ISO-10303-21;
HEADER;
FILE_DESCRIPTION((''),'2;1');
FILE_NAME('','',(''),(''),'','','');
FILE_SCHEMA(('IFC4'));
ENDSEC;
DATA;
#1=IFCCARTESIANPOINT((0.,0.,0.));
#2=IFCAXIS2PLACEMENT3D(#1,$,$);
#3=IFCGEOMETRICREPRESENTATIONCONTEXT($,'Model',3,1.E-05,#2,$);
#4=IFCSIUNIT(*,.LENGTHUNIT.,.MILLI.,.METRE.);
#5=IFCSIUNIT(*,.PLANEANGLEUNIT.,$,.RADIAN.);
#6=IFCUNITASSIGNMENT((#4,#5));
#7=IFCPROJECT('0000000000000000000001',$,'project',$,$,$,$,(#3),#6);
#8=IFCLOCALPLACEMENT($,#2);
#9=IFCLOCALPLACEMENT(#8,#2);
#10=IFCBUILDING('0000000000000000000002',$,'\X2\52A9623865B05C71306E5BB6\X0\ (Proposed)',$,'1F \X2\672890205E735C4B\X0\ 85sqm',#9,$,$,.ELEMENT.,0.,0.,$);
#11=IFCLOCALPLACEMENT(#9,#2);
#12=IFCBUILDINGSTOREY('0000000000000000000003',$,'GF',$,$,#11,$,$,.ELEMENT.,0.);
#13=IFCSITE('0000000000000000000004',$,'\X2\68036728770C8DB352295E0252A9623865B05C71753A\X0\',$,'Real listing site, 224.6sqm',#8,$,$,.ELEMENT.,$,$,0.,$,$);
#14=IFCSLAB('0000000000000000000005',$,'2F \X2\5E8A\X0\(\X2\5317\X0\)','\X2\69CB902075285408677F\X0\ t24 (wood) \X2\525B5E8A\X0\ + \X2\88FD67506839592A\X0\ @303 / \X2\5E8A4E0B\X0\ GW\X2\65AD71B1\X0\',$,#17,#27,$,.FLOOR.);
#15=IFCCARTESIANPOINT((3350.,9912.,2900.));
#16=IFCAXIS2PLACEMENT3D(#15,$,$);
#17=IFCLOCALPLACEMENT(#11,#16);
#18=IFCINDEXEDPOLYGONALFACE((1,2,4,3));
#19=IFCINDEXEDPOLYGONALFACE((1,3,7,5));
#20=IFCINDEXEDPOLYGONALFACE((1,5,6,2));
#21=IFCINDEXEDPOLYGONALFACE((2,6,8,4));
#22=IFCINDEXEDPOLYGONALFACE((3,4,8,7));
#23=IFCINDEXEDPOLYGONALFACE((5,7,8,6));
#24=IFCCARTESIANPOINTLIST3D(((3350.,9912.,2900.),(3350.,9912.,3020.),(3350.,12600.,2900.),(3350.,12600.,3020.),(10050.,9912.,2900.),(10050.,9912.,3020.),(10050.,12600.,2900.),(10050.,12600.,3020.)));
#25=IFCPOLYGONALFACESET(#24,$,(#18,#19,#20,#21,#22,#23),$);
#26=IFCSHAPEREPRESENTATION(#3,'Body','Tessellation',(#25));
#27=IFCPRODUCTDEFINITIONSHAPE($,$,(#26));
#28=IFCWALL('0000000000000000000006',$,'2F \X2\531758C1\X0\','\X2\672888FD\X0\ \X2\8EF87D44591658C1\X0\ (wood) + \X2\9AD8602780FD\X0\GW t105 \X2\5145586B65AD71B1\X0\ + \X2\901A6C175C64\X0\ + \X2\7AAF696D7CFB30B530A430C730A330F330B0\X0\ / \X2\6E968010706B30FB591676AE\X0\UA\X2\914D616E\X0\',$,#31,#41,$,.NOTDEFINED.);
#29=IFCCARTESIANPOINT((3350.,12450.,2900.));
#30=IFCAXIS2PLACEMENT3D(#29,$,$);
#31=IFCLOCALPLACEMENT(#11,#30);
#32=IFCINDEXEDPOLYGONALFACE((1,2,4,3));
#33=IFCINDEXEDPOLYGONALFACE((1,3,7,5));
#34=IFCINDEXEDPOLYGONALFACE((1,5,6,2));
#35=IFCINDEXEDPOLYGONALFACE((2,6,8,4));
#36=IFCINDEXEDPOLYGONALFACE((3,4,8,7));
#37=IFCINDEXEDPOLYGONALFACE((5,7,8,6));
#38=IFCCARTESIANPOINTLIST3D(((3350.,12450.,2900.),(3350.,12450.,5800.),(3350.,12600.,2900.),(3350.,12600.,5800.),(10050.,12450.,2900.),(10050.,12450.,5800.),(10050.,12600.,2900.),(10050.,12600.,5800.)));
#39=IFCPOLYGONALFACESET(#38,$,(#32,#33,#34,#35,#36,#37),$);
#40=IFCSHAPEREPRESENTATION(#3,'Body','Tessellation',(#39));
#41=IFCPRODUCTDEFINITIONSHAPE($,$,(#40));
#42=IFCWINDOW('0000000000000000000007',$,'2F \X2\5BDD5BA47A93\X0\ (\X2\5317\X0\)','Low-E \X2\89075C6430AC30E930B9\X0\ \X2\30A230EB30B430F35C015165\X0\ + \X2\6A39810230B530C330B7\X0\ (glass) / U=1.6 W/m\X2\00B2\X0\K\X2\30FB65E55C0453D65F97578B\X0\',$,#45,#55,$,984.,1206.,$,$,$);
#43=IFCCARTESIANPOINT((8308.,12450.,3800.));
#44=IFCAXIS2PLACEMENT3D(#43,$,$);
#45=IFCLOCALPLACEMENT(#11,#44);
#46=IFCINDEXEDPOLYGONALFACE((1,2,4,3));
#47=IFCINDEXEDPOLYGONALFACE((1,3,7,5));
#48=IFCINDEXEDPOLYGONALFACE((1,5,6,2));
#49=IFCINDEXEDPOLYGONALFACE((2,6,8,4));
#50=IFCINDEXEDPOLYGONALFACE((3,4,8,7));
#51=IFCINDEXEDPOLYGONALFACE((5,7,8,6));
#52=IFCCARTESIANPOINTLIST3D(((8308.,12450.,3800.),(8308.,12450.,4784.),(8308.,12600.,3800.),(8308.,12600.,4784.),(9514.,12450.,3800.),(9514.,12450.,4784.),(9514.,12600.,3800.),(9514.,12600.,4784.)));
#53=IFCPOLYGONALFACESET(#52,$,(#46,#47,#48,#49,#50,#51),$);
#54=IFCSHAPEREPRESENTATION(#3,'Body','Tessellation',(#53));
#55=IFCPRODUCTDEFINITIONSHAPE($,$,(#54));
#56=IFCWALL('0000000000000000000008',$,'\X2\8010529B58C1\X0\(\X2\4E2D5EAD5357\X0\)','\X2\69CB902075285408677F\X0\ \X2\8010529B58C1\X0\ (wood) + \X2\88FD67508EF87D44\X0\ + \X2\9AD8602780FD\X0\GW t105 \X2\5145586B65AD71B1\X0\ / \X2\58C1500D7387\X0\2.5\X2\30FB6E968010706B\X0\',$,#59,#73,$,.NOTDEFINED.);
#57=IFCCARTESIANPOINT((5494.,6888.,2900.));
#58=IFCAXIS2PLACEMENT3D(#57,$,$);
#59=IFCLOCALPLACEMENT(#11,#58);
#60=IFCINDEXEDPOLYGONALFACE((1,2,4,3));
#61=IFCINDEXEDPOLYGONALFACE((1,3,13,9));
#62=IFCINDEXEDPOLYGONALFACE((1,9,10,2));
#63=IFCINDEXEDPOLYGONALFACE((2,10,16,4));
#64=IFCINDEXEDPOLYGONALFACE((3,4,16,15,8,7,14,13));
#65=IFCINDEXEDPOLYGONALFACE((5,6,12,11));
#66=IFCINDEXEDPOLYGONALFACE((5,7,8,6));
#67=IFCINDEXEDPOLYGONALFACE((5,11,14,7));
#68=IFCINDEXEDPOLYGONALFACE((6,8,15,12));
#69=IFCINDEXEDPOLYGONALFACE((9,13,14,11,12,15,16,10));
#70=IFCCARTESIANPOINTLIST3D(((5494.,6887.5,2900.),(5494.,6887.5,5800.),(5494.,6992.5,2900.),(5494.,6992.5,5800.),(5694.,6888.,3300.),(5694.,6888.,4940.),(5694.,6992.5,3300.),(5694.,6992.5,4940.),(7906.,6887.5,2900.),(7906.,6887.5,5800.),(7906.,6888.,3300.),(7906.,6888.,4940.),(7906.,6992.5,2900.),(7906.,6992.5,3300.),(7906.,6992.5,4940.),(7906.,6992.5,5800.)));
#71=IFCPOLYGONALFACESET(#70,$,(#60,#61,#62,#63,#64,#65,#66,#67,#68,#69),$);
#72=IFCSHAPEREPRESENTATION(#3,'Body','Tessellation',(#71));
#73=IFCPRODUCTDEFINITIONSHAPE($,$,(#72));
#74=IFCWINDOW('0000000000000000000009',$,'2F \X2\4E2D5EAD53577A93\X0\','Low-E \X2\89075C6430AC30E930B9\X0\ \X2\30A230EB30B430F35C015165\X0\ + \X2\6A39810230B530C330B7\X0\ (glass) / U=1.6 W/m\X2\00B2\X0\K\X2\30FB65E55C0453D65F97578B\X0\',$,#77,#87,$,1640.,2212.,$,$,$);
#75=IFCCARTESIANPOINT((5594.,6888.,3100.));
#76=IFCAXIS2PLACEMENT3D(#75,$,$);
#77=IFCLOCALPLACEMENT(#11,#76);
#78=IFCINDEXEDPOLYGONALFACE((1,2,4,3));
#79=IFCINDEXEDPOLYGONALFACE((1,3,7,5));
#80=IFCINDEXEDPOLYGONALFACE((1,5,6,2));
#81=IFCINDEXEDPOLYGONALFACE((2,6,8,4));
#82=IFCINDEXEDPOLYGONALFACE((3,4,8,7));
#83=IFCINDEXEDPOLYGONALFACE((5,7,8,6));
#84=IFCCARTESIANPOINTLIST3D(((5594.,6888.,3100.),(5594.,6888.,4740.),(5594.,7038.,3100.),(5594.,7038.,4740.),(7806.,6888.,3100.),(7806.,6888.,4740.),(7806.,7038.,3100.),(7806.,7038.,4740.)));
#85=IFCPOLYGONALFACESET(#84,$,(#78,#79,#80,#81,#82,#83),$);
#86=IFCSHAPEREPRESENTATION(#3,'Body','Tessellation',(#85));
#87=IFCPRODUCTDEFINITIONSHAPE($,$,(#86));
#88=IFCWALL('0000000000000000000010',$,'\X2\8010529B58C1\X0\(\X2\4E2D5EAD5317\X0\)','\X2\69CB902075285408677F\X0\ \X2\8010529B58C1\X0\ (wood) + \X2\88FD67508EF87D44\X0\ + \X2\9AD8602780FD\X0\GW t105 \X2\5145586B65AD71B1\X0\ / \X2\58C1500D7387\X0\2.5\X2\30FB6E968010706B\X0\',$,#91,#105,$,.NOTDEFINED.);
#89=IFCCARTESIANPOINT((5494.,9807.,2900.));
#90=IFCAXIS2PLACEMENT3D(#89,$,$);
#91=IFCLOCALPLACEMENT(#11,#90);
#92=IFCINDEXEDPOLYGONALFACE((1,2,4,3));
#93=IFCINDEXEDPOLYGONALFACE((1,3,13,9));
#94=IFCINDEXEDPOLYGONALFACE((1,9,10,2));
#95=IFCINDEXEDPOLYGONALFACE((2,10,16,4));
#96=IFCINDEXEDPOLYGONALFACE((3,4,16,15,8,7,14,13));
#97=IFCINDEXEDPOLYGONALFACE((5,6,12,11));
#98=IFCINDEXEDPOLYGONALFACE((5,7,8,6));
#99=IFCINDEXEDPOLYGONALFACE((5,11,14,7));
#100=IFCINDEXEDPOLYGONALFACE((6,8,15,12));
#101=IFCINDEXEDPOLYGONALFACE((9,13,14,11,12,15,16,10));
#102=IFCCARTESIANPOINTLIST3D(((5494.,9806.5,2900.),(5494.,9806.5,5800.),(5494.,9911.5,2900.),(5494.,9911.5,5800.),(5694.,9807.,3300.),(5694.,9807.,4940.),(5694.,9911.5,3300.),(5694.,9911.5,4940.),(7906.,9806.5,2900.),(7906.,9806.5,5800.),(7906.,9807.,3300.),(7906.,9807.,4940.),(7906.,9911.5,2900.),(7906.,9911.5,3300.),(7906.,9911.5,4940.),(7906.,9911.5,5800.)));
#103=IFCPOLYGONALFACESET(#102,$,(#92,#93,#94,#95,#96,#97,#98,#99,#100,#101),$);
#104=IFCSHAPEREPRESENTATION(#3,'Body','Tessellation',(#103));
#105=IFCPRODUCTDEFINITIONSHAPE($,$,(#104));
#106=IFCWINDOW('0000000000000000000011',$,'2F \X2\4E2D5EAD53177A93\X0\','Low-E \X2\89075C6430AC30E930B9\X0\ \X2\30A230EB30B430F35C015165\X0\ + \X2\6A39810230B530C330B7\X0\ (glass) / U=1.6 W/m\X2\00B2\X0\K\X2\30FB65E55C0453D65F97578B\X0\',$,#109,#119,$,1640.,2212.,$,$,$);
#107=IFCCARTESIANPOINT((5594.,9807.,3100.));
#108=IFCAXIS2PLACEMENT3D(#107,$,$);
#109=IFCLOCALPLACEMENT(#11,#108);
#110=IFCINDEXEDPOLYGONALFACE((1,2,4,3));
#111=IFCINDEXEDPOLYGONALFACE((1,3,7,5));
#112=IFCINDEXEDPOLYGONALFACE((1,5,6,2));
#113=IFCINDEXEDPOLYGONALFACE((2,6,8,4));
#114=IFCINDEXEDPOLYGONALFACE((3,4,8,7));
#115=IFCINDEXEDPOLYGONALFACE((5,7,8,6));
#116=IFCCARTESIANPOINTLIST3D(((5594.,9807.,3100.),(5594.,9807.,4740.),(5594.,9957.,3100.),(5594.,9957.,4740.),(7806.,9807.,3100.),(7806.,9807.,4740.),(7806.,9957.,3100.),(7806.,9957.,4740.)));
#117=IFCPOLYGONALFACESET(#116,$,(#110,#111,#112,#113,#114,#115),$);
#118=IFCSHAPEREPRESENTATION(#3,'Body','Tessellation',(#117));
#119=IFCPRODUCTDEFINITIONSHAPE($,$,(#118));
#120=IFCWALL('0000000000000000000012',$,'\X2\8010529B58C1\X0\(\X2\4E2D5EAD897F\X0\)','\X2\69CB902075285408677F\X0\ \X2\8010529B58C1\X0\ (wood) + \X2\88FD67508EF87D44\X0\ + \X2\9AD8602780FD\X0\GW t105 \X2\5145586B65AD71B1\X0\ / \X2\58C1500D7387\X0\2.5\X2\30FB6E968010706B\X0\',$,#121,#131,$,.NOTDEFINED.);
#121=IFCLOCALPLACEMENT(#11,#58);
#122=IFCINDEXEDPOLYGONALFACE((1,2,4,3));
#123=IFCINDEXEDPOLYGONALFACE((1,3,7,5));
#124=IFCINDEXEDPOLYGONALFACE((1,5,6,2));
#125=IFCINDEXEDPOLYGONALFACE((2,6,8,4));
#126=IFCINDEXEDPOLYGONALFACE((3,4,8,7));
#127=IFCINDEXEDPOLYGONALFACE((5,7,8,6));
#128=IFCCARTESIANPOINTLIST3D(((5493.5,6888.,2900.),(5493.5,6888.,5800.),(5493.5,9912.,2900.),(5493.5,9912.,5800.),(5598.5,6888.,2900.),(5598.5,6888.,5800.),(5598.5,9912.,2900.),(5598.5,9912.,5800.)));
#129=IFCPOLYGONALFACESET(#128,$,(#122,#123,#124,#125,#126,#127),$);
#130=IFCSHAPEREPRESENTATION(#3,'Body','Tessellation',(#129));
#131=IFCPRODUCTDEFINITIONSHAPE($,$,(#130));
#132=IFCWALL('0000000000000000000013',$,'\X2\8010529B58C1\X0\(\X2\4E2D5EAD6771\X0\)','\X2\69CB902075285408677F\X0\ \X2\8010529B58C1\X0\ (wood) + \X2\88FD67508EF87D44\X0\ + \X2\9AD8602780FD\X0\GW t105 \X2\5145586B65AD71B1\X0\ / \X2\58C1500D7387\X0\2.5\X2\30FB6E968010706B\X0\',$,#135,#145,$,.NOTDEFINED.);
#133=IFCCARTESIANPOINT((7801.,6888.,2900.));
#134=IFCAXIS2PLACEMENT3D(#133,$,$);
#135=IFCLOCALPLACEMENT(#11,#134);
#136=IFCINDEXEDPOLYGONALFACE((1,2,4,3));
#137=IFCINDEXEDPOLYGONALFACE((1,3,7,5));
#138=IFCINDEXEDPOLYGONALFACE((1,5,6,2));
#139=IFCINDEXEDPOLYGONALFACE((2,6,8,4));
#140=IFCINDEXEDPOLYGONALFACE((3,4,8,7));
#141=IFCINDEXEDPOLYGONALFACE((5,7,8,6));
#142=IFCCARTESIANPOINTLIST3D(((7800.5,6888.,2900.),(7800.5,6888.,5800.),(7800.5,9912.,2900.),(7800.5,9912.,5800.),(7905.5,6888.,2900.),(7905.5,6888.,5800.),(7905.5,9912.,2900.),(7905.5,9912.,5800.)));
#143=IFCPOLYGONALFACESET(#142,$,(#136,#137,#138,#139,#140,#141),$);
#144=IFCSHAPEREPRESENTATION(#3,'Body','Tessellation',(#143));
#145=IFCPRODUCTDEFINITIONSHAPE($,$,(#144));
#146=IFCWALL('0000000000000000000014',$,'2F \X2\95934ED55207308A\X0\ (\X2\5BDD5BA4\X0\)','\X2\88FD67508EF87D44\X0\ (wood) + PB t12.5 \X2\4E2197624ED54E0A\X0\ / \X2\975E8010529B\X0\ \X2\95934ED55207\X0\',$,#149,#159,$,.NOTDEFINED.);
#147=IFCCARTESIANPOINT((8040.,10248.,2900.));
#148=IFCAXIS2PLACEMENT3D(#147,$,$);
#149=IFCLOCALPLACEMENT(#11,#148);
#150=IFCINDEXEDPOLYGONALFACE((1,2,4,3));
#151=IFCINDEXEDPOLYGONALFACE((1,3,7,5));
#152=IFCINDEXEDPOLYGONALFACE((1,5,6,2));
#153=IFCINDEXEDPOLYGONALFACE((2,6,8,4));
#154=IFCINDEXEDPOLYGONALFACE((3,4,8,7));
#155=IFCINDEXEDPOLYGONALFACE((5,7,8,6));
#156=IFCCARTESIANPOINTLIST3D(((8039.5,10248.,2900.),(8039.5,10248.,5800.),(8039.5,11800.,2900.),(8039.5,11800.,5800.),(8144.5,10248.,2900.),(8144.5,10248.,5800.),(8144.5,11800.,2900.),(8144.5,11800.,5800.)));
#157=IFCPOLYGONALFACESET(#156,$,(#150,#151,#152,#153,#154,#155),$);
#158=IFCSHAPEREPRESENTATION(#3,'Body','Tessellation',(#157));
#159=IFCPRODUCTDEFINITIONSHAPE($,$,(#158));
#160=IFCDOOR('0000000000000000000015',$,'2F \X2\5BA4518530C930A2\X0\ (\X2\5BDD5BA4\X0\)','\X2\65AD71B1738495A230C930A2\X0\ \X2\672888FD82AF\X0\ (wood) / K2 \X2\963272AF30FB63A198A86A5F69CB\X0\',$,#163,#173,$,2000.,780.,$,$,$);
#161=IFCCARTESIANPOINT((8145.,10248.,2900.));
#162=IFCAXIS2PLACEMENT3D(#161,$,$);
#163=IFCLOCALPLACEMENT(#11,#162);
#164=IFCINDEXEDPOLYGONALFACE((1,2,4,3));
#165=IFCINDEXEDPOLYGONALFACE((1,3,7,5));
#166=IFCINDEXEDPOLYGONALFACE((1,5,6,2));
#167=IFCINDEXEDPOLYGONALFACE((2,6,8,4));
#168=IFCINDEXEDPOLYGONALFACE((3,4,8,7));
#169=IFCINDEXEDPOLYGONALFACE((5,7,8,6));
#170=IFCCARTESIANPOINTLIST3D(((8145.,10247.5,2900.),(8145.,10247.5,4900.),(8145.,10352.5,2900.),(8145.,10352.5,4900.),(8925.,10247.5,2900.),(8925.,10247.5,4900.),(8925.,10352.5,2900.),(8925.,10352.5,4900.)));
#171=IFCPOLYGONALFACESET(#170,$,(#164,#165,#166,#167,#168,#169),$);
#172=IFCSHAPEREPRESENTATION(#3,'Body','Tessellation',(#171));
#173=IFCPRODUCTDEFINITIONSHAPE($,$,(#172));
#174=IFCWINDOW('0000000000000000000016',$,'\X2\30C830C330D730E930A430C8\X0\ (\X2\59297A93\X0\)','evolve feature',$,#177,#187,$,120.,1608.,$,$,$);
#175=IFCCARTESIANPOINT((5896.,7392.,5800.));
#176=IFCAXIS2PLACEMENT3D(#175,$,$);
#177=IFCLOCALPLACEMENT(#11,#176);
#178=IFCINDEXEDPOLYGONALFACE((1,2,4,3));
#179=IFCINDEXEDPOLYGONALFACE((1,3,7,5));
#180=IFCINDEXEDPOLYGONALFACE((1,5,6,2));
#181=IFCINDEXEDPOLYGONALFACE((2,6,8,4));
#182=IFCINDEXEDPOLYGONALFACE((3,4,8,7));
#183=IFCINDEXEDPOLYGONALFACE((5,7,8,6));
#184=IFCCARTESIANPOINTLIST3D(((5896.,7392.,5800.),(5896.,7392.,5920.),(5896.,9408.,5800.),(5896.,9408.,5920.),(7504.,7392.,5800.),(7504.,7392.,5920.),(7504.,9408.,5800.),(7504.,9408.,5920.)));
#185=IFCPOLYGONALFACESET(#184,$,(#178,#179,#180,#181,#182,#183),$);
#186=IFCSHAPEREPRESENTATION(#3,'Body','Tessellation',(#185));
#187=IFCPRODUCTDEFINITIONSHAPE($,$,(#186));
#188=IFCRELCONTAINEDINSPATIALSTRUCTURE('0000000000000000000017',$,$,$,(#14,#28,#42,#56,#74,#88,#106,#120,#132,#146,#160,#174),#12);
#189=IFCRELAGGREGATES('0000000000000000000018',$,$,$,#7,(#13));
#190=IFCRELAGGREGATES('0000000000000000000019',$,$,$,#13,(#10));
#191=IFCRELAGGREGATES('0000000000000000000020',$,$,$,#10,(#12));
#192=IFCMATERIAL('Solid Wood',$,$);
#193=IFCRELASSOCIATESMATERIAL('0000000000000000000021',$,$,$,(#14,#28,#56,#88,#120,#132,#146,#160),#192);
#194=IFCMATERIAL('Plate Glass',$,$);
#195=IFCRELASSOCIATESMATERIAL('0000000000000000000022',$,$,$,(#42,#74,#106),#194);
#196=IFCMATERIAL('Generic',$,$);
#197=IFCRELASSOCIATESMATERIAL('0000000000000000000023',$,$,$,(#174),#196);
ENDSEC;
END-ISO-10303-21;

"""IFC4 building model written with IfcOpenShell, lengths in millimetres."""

from ifc_helpers import new_model, si_unit, frame, frame_2d, origin, place, context, project, spatial, rectangle, extrude, material, element, fill, save


model = new_model("IFC4")

# Units and contexts
model_context = context("Model", 3, precision=1e-05, world=origin())
ifc_project = project(units=[si_unit("LENGTHUNIT", "METRE", prefix="MILLI"), si_unit("PLANEANGLEUNIT", "RADIAN")], contexts=[model_context])

# Site, building, storey
site_placement = place(None, origin())
site = spatial("IfcSite", under=ifc_project, at=site_placement, Name="栃木県足利市助戸新山町", ObjectType="Real listing site, 224.6sqm", CompositionType="ELEMENT", RefElevation=0.0)
building_placement = place(site_placement, origin())
building = spatial("IfcBuilding", under=site, at=building_placement, Name="助戸新山の家 (Proposed)", ObjectType="1F 木造平屋 85sqm", CompositionType="ELEMENT", ElevationOfRefHeight=0.0, ElevationOfTerrain=0.0)
storey_placement = place(building_placement, origin())
storey = spatial("IfcBuildingStorey", under=building, at=storey_placement, Name="GF", CompositionType="ELEMENT", Elevation=0.0)

# Slab
ifc_material_1 = material(Name="Solid Wood")
slab_placement = place(storey_placement, frame((3350.0, 9912.0, 2900.0)))
element("IfcSlab", 1, at=slab_placement, inside=storey, material=ifc_material_1, Name="2F 床(北)", Description="構造用合板 t24 (wood) 剛床 + 製材根太 @303 / 床下 GW断熱", PredefinedType="FLOOR", context=model_context, shape_type="SweptSolid", body=[
    extrude(rectangle(XDim=6700.0, YDim=2688.0, at=frame_2d((3350.0, 1344.0))), frame((3350.0, 9912.0, 2900.0)), (0.0, 0.0, 1.0), 120.0),
])

# Walls, openings, windows
wall_1_placement = place(storey_placement, frame((3350.0, 12450.0, 2900.0)))
wall_1 = element("IfcWall", 2, at=wall_1_placement, inside=storey, material=ifc_material_1, Name="2F 北壁", Description="木製 軸組外壁 (wood) + 高性能GW t105 充填断熱 + 通気層 + 窯業系サイディング / 準耐火・外皮UA配慮", PredefinedType="NOTDEFINED", context=model_context, shape_type="SweptSolid", body=[
    extrude(rectangle(XDim=6700.0, YDim=150.0, at=frame_2d((3350.0, 75.0))), frame((3350.0, 12450.0, 2900.0)), (0.0, 0.0, 1.0), 2900.0),
])
opening_1_placement = place(storey_placement, frame((8308.0, 12450.0, 3800.0)))
opening_1 = element("IfcOpeningElement", 3, at=opening_1_placement, cuts=wall_1, PredefinedType="NOTDEFINED", context=model_context, shape_type="SweptSolid", body=[
    extrude(rectangle(XDim=1206.0, YDim=150.0, at=frame_2d((603.0, 75.0))), frame((8308.0, 12450.0, 3800.0)), (0.0, 0.0, 1.0), 984.0),
])
ifc_material_2 = material(Name="Plate Glass")
window_1_placement = place(storey_placement, frame((8308.0, 12450.0, 3800.0)))
window_1 = element("IfcWindow", 4, at=window_1_placement, inside=storey, material=ifc_material_2, Name="2F 寝室窓 (北)", Description="Low-E 複層ガラス アルゴン封入 + 樹脂サッシ (glass) / U=1.6 W/m²K・日射取得型", OverallHeight=984.0, OverallWidth=1206.0, context=model_context, shape_type="SweptSolid", body=[
    extrude(rectangle(XDim=1206.0, YDim=150.0, at=frame_2d((603.0, 75.0))), frame((8308.0, 12450.0, 3800.0)), (0.0, 0.0, 1.0), 984.0),
])
fill(opening_1, window_1)
wall_2_placement = place(storey_placement, frame((5494.0, 6888.0, 2900.0)))
wall_2 = element("IfcWall", 5, at=wall_2_placement, inside=storey, material=ifc_material_1, Name="耐力壁(中庭南)", Description="構造用合板 耐力壁 (wood) + 製材軸組 + 高性能GW t105 充填断熱 / 壁倍率2.5・準耐火", PredefinedType="NOTDEFINED", context=model_context, shape_type="SweptSolid", body=[
    extrude(rectangle(XDim=2412.0, YDim=105.0, at=frame_2d((1206.0, 52.0))), frame((5494.0, 6888.0, 2900.0)), (0.0, 0.0, 1.0), 2900.0),
])
opening_2_placement = place(storey_placement, frame((5594.0, 6888.0, 3100.0)))
opening_2 = element("IfcOpeningElement", 6, at=opening_2_placement, cuts=wall_2, PredefinedType="NOTDEFINED", context=model_context, shape_type="SweptSolid", body=[
    extrude(rectangle(XDim=2212.0, YDim=150.0, at=frame_2d((1106.0, 75.0))), frame((5594.0, 6888.0, 3100.0)), (0.0, 0.0, 1.0), 1640.0),
])
window_2_placement = place(storey_placement, frame((5594.0, 6888.0, 3100.0)))
window_2 = element("IfcWindow", 7, at=window_2_placement, inside=storey, material=ifc_material_2, Name="2F 中庭南窓", Description="Low-E 複層ガラス アルゴン封入 + 樹脂サッシ (glass) / U=1.6 W/m²K・日射取得型", OverallHeight=1640.0, OverallWidth=2212.0, context=model_context, shape_type="SweptSolid", body=[
    extrude(rectangle(XDim=2212.0, YDim=150.0, at=frame_2d((1106.0, 75.0))), frame((5594.0, 6888.0, 3100.0)), (0.0, 0.0, 1.0), 1640.0),
])
fill(opening_2, window_2)
wall_3_placement = place(storey_placement, frame((5494.0, 9807.0, 2900.0)))
wall_3 = element("IfcWall", 8, at=wall_3_placement, inside=storey, material=ifc_material_1, Name="耐力壁(中庭北)", Description="構造用合板 耐力壁 (wood) + 製材軸組 + 高性能GW t105 充填断熱 / 壁倍率2.5・準耐火", PredefinedType="NOTDEFINED", context=model_context, shape_type="SweptSolid", body=[
    extrude(rectangle(XDim=2412.0, YDim=105.0, at=frame_2d((1206.0, 52.0))), frame((5494.0, 9807.0, 2900.0)), (0.0, 0.0, 1.0), 2900.0),
])
opening_3_placement = place(storey_placement, frame((5594.0, 9807.0, 3100.0)))
opening_3 = element("IfcOpeningElement", 9, at=opening_3_placement, cuts=wall_3, PredefinedType="NOTDEFINED", context=model_context, shape_type="SweptSolid", body=[
    extrude(rectangle(XDim=2212.0, YDim=150.0, at=frame_2d((1106.0, 75.0))), frame((5594.0, 9807.0, 3100.0)), (0.0, 0.0, 1.0), 1640.0),
])
window_3_placement = place(storey_placement, frame((5594.0, 9807.0, 3100.0)))
window_3 = element("IfcWindow", 10, at=window_3_placement, inside=storey, material=ifc_material_2, Name="2F 中庭北窓", Description="Low-E 複層ガラス アルゴン封入 + 樹脂サッシ (glass) / U=1.6 W/m²K・日射取得型", OverallHeight=1640.0, OverallWidth=2212.0, context=model_context, shape_type="SweptSolid", body=[
    extrude(rectangle(XDim=2212.0, YDim=150.0, at=frame_2d((1106.0, 75.0))), frame((5594.0, 9807.0, 3100.0)), (0.0, 0.0, 1.0), 1640.0),
])
fill(opening_3, window_3)

# Walls
wall_4_placement = place(storey_placement, frame((5494.0, 6888.0, 2900.0)))
element("IfcWall", 11, at=wall_4_placement, inside=storey, material=ifc_material_1, Name="耐力壁(中庭西)", Description="構造用合板 耐力壁 (wood) + 製材軸組 + 高性能GW t105 充填断熱 / 壁倍率2.5・準耐火", PredefinedType="NOTDEFINED", context=model_context, shape_type="SweptSolid", body=[
    extrude(rectangle(XDim=105.0, YDim=3024.0, at=frame_2d((52.0, 1512.0))), frame((5494.0, 6888.0, 2900.0)), (0.0, 0.0, 1.0), 2900.0),
])
wall_5_placement = place(storey_placement, frame((7801.0, 6888.0, 2900.0)))
element("IfcWall", 12, at=wall_5_placement, inside=storey, material=ifc_material_1, Name="耐力壁(中庭東)", Description="構造用合板 耐力壁 (wood) + 製材軸組 + 高性能GW t105 充填断熱 / 壁倍率2.5・準耐火", PredefinedType="NOTDEFINED", context=model_context, shape_type="SweptSolid", body=[
    extrude(rectangle(XDim=105.0, YDim=3024.0, at=frame_2d((52.0, 1512.0))), frame((7801.0, 6888.0, 2900.0)), (0.0, 0.0, 1.0), 2900.0),
])
wall_6_placement = place(storey_placement, frame((8040.0, 10248.0, 2900.0)))
element("IfcWall", 13, at=wall_6_placement, inside=storey, material=ifc_material_1, Name="2F 間仕切り (寝室)", Description="製材軸組 (wood) + PB t12.5 両面仕上 / 非耐力 間仕切", PredefinedType="NOTDEFINED", context=model_context, shape_type="SweptSolid", body=[
    extrude(rectangle(XDim=105.0, YDim=1552.0, at=frame_2d((52.0, 776.0))), frame((8040.0, 10248.0, 2900.0)), (0.0, 0.0, 1.0), 2900.0),
])

# Door
door_placement = place(storey_placement, frame((8145.0, 10248.0, 2900.0)))
element("IfcDoor", 14, at=door_placement, inside=storey, material=ifc_material_1, Name="2F 室内ドア (寝室)", Description="断熱玄関ドア 木製芯 (wood) / K2 防犯・採風機構", OverallHeight=2000.0, OverallWidth=780.0, context=model_context, shape_type="SweptSolid", body=[
    extrude(rectangle(XDim=780.0, YDim=105.0, at=frame_2d((390.0, 52.0))), frame((8145.0, 10248.0, 2900.0)), (0.0, 0.0, 1.0), 2000.0),
])

# Window
ifc_material_3 = material(Name="Generic")
window_4_placement = place(storey_placement, frame((5896.0, 7392.0, 5800.0)))
element("IfcWindow", 15, at=window_4_placement, inside=storey, material=ifc_material_3, Name="トップライト (天窓)", Description="evolve feature", OverallHeight=120.0, OverallWidth=1608.0, context=model_context, shape_type="SweptSolid", body=[
    extrude(rectangle(XDim=1608.0, YDim=2016.0, at=frame_2d((804.0, 1008.0))), frame((5896.0, 7392.0, 5800.0)), (0.0, 0.0, 1.0), 120.0),
])

save(model, "model.ifc")
